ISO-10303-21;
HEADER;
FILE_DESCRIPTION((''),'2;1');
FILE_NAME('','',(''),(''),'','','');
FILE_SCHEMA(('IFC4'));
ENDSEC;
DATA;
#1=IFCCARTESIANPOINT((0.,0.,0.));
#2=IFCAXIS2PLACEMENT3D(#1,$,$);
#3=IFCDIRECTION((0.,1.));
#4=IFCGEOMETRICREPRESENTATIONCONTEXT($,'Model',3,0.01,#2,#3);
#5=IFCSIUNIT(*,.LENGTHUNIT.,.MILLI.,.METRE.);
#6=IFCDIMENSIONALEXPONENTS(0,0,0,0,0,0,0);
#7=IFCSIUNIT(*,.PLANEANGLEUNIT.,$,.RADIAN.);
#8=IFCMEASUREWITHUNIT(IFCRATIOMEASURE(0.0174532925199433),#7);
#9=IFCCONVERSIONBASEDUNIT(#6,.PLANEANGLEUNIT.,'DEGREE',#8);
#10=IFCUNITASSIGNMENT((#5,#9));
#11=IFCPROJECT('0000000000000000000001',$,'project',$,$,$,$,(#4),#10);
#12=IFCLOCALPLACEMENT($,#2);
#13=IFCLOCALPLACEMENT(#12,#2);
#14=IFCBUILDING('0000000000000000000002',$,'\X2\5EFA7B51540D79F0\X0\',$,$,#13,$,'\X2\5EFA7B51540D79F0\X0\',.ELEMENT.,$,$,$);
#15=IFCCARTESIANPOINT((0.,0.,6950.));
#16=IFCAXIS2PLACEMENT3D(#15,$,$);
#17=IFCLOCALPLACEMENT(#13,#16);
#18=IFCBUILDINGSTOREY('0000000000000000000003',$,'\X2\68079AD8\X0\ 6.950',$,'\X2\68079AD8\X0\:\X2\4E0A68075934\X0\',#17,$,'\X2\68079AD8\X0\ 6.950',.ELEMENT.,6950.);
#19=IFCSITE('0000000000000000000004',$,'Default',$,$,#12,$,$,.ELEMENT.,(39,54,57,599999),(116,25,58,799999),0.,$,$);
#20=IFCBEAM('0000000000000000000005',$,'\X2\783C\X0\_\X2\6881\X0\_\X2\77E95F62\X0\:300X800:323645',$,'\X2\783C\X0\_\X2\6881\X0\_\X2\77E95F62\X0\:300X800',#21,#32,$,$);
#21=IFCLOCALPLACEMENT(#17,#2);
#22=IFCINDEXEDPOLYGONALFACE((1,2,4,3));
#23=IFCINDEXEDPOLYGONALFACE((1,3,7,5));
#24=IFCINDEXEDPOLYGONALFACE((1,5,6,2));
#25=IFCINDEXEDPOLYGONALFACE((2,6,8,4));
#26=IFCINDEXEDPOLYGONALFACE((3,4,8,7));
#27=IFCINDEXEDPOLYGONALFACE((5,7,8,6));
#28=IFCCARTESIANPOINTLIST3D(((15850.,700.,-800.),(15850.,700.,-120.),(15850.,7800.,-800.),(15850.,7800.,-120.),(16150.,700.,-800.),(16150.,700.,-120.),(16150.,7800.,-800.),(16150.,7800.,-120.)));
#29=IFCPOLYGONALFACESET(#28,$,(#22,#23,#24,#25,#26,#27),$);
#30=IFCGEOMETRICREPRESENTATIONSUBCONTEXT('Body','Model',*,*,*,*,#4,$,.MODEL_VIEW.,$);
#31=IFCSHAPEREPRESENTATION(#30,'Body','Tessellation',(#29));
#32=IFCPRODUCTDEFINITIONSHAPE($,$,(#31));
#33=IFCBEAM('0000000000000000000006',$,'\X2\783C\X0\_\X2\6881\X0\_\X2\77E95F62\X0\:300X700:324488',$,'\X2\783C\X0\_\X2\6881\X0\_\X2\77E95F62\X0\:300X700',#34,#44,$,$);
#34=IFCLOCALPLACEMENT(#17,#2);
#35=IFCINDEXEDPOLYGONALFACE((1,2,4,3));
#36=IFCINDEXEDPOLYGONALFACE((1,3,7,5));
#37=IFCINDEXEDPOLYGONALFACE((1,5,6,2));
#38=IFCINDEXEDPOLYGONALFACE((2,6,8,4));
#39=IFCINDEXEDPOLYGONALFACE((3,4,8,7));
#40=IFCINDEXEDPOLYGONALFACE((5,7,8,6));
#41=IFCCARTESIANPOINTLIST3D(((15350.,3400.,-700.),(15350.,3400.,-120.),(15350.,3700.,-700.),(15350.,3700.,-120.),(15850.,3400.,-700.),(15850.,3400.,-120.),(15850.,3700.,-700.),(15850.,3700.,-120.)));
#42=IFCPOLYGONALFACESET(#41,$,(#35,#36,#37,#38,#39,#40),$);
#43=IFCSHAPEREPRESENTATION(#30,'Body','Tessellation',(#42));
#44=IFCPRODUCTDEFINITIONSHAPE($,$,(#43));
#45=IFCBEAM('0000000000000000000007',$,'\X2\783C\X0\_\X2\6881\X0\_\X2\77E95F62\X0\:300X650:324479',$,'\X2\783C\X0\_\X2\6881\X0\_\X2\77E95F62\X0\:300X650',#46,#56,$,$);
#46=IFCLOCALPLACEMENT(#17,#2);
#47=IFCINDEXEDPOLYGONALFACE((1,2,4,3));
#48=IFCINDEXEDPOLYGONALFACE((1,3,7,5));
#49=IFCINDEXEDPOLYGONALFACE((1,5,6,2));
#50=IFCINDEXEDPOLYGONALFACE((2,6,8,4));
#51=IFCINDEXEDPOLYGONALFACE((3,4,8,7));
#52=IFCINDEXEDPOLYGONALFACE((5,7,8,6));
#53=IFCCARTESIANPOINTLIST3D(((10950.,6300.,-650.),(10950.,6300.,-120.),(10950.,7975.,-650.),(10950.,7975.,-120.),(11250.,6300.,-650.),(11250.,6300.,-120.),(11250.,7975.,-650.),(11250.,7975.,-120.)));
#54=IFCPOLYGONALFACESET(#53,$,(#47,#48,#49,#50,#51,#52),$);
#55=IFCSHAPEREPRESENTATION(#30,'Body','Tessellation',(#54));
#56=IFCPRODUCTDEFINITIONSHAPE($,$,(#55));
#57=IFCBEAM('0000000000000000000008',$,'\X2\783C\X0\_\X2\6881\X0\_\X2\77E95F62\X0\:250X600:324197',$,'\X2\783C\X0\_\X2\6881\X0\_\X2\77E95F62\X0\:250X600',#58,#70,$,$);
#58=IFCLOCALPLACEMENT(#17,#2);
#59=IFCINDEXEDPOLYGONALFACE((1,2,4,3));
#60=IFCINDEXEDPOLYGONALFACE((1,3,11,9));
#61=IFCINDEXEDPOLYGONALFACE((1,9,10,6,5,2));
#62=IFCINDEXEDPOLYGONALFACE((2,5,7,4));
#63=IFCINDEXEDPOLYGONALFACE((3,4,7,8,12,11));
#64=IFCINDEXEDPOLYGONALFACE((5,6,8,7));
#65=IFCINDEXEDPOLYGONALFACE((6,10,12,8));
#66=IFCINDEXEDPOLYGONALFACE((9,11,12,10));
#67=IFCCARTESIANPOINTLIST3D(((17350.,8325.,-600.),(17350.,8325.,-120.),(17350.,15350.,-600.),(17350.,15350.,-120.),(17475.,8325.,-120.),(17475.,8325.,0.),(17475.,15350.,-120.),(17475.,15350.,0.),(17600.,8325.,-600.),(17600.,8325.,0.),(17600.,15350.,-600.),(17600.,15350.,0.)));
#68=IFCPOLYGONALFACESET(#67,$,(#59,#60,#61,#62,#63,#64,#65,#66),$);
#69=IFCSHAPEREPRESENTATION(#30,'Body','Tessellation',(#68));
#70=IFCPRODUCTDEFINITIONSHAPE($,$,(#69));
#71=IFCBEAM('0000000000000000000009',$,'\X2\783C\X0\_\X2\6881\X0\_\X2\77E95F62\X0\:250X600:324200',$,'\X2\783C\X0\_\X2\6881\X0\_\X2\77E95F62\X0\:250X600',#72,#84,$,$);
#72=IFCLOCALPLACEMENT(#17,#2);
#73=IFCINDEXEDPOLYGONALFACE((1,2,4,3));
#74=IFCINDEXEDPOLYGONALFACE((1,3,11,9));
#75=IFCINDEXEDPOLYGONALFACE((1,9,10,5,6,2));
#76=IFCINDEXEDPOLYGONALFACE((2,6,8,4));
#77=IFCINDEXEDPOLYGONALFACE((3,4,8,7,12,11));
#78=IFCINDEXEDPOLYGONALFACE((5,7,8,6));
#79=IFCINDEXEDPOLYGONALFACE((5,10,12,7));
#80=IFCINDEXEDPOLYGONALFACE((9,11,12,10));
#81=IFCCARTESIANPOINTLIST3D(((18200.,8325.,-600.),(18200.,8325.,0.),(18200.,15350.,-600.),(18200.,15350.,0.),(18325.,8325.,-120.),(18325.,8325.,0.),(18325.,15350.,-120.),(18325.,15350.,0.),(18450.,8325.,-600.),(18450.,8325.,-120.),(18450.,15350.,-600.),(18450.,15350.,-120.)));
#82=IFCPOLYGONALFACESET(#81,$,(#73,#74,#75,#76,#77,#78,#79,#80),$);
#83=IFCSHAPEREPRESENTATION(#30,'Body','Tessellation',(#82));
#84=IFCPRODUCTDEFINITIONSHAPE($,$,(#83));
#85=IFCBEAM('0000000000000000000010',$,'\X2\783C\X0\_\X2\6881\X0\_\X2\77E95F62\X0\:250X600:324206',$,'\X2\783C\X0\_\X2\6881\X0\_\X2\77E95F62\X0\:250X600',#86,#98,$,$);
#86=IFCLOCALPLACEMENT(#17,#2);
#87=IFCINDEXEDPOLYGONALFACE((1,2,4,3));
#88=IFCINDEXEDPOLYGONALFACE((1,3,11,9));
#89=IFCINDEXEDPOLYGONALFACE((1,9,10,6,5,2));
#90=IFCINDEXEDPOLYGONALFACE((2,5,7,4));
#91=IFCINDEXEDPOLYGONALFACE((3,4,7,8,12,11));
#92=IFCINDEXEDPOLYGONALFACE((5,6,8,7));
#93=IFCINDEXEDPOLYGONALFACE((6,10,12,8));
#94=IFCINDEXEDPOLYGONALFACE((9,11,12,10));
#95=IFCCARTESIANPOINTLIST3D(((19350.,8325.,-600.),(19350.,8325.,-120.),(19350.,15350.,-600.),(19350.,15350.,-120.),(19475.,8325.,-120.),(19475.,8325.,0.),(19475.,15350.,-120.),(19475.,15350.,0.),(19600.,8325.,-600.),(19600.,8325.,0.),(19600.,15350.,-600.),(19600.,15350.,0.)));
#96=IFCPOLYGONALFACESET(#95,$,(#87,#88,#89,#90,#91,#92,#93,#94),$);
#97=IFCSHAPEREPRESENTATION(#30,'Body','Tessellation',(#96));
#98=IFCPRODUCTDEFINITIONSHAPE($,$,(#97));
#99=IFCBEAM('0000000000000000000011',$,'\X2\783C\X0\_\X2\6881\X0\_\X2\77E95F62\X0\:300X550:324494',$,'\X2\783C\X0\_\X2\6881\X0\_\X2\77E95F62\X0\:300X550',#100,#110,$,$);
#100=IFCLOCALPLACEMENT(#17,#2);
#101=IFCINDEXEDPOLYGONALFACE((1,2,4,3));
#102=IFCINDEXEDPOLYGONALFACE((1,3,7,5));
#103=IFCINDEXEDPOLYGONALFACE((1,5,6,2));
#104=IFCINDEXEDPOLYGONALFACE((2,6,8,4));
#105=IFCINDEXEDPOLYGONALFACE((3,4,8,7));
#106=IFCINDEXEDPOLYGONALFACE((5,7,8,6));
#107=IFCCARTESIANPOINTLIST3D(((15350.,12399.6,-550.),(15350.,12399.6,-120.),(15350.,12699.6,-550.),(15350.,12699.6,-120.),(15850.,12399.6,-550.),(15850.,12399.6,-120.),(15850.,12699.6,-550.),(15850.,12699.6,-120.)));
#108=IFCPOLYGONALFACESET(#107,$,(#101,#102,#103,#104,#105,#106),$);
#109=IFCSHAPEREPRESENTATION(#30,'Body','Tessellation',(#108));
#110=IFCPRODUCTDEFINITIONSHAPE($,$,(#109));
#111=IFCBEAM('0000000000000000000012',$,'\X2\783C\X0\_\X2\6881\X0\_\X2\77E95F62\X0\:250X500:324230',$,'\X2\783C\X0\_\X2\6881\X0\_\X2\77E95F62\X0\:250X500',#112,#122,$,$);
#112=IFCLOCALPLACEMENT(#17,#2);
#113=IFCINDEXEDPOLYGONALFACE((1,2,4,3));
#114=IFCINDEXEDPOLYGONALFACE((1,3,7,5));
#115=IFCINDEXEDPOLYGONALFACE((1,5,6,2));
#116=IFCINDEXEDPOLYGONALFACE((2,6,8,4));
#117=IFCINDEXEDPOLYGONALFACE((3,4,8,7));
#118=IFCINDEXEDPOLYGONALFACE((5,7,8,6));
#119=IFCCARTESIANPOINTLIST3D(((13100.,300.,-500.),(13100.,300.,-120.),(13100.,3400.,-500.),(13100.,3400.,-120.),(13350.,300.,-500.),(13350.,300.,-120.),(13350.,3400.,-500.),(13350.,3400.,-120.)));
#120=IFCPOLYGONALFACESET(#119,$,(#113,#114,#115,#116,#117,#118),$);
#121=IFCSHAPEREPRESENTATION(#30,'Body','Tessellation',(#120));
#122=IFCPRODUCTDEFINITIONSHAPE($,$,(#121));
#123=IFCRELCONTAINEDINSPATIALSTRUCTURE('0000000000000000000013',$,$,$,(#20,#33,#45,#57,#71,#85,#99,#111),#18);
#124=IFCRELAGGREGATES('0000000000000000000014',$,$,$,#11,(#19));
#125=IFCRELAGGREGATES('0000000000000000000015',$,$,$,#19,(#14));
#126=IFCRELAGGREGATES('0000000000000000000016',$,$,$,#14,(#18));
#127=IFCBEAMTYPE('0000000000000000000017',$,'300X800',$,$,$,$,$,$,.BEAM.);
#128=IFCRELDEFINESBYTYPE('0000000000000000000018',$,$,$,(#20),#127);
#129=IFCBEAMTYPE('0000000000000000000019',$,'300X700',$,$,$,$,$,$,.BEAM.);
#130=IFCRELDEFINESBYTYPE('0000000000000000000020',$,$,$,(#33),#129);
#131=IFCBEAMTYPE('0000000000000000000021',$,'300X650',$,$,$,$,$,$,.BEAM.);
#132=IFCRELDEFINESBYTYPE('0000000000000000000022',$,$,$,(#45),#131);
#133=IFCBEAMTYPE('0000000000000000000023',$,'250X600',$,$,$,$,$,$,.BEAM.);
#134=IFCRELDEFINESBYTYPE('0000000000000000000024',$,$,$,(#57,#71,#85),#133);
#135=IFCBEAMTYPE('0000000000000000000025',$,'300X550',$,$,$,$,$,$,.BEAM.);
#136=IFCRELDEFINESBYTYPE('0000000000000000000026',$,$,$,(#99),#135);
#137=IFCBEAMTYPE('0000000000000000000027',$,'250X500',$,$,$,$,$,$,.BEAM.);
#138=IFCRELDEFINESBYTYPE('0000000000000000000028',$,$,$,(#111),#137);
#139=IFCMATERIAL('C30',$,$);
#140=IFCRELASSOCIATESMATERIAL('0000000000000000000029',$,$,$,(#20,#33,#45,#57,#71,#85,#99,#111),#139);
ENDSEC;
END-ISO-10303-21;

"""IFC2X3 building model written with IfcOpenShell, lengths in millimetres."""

from ifc_helpers import new_model, entity, si_unit, converted_unit, direction, frame, frame_2d, origin, origin_2d_with_axis, place, context, subcontext, project, spatial, polyline, rectangle, outline, extrude, material, type_object, element, save


model = new_model("IFC2X3")

# Units and contexts
model_context = context("Model", 3, precision=0.01, world=origin(), true_north=direction((0.0, 1.0)))
body_context = subcontext(model_context, "Body", "Model", "MODEL_VIEW")
ifc_project = project(units=[si_unit("LENGTHUNIT", "METRE", prefix="MILLI"), converted_unit("PLANEANGLEUNIT", "DEGREE", entity("IfcRatioMeasure", 0.0174532925199433), si_unit("PLANEANGLEUNIT", "RADIAN"), dimensions=[0, 0, 0, 0, 0, 0, 0])], contexts=[model_context])

# Site, building, storey
site_placement = place(None, origin())
site = spatial("IfcSite", under=ifc_project, at=site_placement, Name="Default", CompositionType="ELEMENT", RefLatitude=(39, 54, 57, 599999), RefLongitude=(116, 25, 58, 799999), RefElevation=0.0)
building_placement = place(site_placement, origin())
building = spatial("IfcBuilding", under=site, at=building_placement, Name="建筑名称", LongName="建筑名称", CompositionType="ELEMENT")
storey_placement = place(building_placement, frame((0.0, 0.0, 6950.0)))
storey = spatial("IfcBuildingStorey", under=building, at=storey_placement, Name="标高 6.950", ObjectType="标高:上标头", LongName="标高 6.950", CompositionType="ELEMENT", Elevation=6950.0)

# Beams
ifc_material_1 = material(Name="C30")
beam_type_1 = type_object("IfcBeamType", Name="300X800", PredefinedType="BEAM")
beam_1_placement = place(storey_placement, frame((16000.0, 150.0, 0.0), z_axis=(0.0, 0.0, 1.0), x_axis=(0.0, 1.0, 0.0)))
element("IfcBeam", 1, at=beam_1_placement, inside=storey, type_object=beam_type_1, material=ifc_material_1, Name="砼_梁_矩形:300X800:323645", ObjectType="砼_梁_矩形:300X800", context=body_context, shape_type="SweptSolid", body=[
    extrude(rectangle(XDim=680.0, YDim=300.0, at=frame_2d((0.0, 0.0), x_axis=(1.0, 0.0))), frame((550.0, 0.0, -460.0), z_axis=(1.0, 0.0, 0.0), x_axis=(0.0, 0.0, -1.0)), (0.0, 0.0, 1.0), 7100.0),
])
beam_type_2 = type_object("IfcBeamType", Name="300X700", PredefinedType="BEAM")
beam_2_placement = place(storey_placement, frame((15100.0, 3700.0, 0.0)))
element("IfcBeam", 2, at=beam_2_placement, inside=storey, type_object=beam_type_2, material=ifc_material_1, Name="砼_梁_矩形:300X700:324488", ObjectType="砼_梁_矩形:300X700", context=body_context, shape_type="SweptSolid", body=[
    extrude(rectangle(XDim=580.0, YDim=300.0, at=origin_2d_with_axis()), frame((250.0, -150.0, -410.0), z_axis=(1.0, 0.0, 0.0), x_axis=(0.0, 0.0, -1.0)), (0.0, 0.0, 1.0), 500.0),
])
beam_type_3 = type_object("IfcBeamType", Name="300X650", PredefinedType="BEAM")
beam_3_placement = place(storey_placement, frame((11100.0, 6150.0, 0.0), z_axis=(0.0, 0.0, 1.0), x_axis=(0.0, 1.0, 0.0)))
element("IfcBeam", 3, at=beam_3_placement, inside=storey, type_object=beam_type_3, material=ifc_material_1, Name="砼_梁_矩形:300X650:324479", ObjectType="砼_梁_矩形:300X650", context=body_context, shape_type="SweptSolid", body=[
    extrude(rectangle(XDim=530.0, YDim=300.0, at=frame_2d((0.0, 0.0), x_axis=(1.0, 0.0))), frame((150.0, 0.0, -385.0), z_axis=(1.0, 0.0, 0.0), x_axis=(0.0, 0.0, -1.0)), (0.0, 0.0, 1.0), 1675.0),
])
beam_type_4 = type_object("IfcBeamType", Name="250X600", PredefinedType="BEAM")
beam_4_placement = place(storey_placement, frame((17600.0, 8150.0, 0.0), z_axis=(0.0, 0.0, 1.0), x_axis=(0.0, 1.0, 0.0)))
element("IfcBeam", 4, at=beam_4_placement, inside=storey, type_object=beam_type_4, material=ifc_material_1, Name="砼_梁_矩形:250X600:324197", ObjectType="砼_梁_矩形:250X600", context=body_context, shape_type="SweptSolid", body=[
    extrude(outline(polyline([(-240.0, -125.0), (360.0, -125.0), (360.0, 125.0), (-120.0, 125.0), (-120.0, 0.0), (-240.0, 0.0), (-240.0, -125.0)])), frame((175.0, 125.0, -240.0), z_axis=(1.0, 0.0, 0.0), x_axis=(0.0, 0.0, -1.0)), (0.0, 0.0, 1.0), 7025.0),
])
beam_5_placement = place(storey_placement, frame((18200.0, 8150.0, 0.0), z_axis=(0.0, 0.0, 1.0), x_axis=(0.0, 1.0, 0.0)))
element("IfcBeam", 5, at=beam_5_placement, inside=storey, type_object=beam_type_4, material=ifc_material_1, Name="砼_梁_矩形:250X600:324200", ObjectType="砼_梁_矩形:250X600", context=body_context, shape_type="SweptSolid", body=[
    extrude(outline(polyline([(-120.0, -125.0), (360.0, -125.0), (360.0, 125.0), (-240.0, 125.0), (-240.0, 0.0), (-120.0, 0.0), (-120.0, -125.0)])), frame((175.0, -125.0, -240.0), z_axis=(1.0, 0.0, 0.0), x_axis=(0.0, 0.0, -1.0)), (0.0, 0.0, 1.0), 7025.0),
])
beam_6_placement = place(storey_placement, frame((19600.0, 8150.0, 0.0), z_axis=(0.0, 0.0, 1.0), x_axis=(0.0, 1.0, 0.0)))
element("IfcBeam", 6, at=beam_6_placement, inside=storey, type_object=beam_type_4, material=ifc_material_1, Name="砼_梁_矩形:250X600:324206", ObjectType="砼_梁_矩形:250X600", context=body_context, shape_type="SweptSolid", body=[
    extrude(outline(polyline([(-240.0, -125.0), (360.0, -125.0), (360.0, 125.0), (-120.0, 125.0), (-120.0, 0.0), (-240.0, 0.0), (-240.0, -125.0)])), frame((175.0, 125.0, -240.0), z_axis=(1.0, 0.0, 0.0), x_axis=(0.0, 0.0, -1.0)), (0.0, 0.0, 1.0), 7025.0),
])
beam_type_5 = type_object("IfcBeamType", Name="300X550", PredefinedType="BEAM")
beam_7_placement = place(storey_placement, frame((15100.0, 12549.6, 0.0)))
element("IfcBeam", 7, at=beam_7_placement, inside=storey, type_object=beam_type_5, material=ifc_material_1, Name="砼_梁_矩形:300X550:324494", ObjectType="砼_梁_矩形:300X550", context=body_context, shape_type="SweptSolid", body=[
    extrude(rectangle(XDim=430.0, YDim=300.0, at=frame_2d((0.0, 0.0), x_axis=(1.0, 0.0))), frame((250.0, 0.0, -335.0), z_axis=(1.0, 0.0, 0.0), x_axis=(0.0, 0.0, -1.0)), (0.0, 0.0, 1.0), 500.0),
])
beam_type_6 = type_object("IfcBeamType", Name="250X500", PredefinedType="BEAM")
beam_8_placement = place(storey_placement, frame((13100.0, 0.0, 0.0), z_axis=(0.0, 0.0, 1.0), x_axis=(0.0, 1.0, 0.0)))
element("IfcBeam", 8, at=beam_8_placement, inside=storey, type_object=beam_type_6, material=ifc_material_1, Name="砼_梁_矩形:250X500:324230", ObjectType="砼_梁_矩形:250X500", context=body_context, shape_type="SweptSolid", body=[
    extrude(rectangle(XDim=380.0, YDim=250.0, at=frame_2d((0.0, 0.0), x_axis=(1.0, 0.0))), frame((300.0, -125.0, -310.0), z_axis=(1.0, 0.0, 0.0), x_axis=(0.0, 0.0, -1.0)), (0.0, 0.0, 1.0), 3100.0),
])

save(model, "model.ifc")
